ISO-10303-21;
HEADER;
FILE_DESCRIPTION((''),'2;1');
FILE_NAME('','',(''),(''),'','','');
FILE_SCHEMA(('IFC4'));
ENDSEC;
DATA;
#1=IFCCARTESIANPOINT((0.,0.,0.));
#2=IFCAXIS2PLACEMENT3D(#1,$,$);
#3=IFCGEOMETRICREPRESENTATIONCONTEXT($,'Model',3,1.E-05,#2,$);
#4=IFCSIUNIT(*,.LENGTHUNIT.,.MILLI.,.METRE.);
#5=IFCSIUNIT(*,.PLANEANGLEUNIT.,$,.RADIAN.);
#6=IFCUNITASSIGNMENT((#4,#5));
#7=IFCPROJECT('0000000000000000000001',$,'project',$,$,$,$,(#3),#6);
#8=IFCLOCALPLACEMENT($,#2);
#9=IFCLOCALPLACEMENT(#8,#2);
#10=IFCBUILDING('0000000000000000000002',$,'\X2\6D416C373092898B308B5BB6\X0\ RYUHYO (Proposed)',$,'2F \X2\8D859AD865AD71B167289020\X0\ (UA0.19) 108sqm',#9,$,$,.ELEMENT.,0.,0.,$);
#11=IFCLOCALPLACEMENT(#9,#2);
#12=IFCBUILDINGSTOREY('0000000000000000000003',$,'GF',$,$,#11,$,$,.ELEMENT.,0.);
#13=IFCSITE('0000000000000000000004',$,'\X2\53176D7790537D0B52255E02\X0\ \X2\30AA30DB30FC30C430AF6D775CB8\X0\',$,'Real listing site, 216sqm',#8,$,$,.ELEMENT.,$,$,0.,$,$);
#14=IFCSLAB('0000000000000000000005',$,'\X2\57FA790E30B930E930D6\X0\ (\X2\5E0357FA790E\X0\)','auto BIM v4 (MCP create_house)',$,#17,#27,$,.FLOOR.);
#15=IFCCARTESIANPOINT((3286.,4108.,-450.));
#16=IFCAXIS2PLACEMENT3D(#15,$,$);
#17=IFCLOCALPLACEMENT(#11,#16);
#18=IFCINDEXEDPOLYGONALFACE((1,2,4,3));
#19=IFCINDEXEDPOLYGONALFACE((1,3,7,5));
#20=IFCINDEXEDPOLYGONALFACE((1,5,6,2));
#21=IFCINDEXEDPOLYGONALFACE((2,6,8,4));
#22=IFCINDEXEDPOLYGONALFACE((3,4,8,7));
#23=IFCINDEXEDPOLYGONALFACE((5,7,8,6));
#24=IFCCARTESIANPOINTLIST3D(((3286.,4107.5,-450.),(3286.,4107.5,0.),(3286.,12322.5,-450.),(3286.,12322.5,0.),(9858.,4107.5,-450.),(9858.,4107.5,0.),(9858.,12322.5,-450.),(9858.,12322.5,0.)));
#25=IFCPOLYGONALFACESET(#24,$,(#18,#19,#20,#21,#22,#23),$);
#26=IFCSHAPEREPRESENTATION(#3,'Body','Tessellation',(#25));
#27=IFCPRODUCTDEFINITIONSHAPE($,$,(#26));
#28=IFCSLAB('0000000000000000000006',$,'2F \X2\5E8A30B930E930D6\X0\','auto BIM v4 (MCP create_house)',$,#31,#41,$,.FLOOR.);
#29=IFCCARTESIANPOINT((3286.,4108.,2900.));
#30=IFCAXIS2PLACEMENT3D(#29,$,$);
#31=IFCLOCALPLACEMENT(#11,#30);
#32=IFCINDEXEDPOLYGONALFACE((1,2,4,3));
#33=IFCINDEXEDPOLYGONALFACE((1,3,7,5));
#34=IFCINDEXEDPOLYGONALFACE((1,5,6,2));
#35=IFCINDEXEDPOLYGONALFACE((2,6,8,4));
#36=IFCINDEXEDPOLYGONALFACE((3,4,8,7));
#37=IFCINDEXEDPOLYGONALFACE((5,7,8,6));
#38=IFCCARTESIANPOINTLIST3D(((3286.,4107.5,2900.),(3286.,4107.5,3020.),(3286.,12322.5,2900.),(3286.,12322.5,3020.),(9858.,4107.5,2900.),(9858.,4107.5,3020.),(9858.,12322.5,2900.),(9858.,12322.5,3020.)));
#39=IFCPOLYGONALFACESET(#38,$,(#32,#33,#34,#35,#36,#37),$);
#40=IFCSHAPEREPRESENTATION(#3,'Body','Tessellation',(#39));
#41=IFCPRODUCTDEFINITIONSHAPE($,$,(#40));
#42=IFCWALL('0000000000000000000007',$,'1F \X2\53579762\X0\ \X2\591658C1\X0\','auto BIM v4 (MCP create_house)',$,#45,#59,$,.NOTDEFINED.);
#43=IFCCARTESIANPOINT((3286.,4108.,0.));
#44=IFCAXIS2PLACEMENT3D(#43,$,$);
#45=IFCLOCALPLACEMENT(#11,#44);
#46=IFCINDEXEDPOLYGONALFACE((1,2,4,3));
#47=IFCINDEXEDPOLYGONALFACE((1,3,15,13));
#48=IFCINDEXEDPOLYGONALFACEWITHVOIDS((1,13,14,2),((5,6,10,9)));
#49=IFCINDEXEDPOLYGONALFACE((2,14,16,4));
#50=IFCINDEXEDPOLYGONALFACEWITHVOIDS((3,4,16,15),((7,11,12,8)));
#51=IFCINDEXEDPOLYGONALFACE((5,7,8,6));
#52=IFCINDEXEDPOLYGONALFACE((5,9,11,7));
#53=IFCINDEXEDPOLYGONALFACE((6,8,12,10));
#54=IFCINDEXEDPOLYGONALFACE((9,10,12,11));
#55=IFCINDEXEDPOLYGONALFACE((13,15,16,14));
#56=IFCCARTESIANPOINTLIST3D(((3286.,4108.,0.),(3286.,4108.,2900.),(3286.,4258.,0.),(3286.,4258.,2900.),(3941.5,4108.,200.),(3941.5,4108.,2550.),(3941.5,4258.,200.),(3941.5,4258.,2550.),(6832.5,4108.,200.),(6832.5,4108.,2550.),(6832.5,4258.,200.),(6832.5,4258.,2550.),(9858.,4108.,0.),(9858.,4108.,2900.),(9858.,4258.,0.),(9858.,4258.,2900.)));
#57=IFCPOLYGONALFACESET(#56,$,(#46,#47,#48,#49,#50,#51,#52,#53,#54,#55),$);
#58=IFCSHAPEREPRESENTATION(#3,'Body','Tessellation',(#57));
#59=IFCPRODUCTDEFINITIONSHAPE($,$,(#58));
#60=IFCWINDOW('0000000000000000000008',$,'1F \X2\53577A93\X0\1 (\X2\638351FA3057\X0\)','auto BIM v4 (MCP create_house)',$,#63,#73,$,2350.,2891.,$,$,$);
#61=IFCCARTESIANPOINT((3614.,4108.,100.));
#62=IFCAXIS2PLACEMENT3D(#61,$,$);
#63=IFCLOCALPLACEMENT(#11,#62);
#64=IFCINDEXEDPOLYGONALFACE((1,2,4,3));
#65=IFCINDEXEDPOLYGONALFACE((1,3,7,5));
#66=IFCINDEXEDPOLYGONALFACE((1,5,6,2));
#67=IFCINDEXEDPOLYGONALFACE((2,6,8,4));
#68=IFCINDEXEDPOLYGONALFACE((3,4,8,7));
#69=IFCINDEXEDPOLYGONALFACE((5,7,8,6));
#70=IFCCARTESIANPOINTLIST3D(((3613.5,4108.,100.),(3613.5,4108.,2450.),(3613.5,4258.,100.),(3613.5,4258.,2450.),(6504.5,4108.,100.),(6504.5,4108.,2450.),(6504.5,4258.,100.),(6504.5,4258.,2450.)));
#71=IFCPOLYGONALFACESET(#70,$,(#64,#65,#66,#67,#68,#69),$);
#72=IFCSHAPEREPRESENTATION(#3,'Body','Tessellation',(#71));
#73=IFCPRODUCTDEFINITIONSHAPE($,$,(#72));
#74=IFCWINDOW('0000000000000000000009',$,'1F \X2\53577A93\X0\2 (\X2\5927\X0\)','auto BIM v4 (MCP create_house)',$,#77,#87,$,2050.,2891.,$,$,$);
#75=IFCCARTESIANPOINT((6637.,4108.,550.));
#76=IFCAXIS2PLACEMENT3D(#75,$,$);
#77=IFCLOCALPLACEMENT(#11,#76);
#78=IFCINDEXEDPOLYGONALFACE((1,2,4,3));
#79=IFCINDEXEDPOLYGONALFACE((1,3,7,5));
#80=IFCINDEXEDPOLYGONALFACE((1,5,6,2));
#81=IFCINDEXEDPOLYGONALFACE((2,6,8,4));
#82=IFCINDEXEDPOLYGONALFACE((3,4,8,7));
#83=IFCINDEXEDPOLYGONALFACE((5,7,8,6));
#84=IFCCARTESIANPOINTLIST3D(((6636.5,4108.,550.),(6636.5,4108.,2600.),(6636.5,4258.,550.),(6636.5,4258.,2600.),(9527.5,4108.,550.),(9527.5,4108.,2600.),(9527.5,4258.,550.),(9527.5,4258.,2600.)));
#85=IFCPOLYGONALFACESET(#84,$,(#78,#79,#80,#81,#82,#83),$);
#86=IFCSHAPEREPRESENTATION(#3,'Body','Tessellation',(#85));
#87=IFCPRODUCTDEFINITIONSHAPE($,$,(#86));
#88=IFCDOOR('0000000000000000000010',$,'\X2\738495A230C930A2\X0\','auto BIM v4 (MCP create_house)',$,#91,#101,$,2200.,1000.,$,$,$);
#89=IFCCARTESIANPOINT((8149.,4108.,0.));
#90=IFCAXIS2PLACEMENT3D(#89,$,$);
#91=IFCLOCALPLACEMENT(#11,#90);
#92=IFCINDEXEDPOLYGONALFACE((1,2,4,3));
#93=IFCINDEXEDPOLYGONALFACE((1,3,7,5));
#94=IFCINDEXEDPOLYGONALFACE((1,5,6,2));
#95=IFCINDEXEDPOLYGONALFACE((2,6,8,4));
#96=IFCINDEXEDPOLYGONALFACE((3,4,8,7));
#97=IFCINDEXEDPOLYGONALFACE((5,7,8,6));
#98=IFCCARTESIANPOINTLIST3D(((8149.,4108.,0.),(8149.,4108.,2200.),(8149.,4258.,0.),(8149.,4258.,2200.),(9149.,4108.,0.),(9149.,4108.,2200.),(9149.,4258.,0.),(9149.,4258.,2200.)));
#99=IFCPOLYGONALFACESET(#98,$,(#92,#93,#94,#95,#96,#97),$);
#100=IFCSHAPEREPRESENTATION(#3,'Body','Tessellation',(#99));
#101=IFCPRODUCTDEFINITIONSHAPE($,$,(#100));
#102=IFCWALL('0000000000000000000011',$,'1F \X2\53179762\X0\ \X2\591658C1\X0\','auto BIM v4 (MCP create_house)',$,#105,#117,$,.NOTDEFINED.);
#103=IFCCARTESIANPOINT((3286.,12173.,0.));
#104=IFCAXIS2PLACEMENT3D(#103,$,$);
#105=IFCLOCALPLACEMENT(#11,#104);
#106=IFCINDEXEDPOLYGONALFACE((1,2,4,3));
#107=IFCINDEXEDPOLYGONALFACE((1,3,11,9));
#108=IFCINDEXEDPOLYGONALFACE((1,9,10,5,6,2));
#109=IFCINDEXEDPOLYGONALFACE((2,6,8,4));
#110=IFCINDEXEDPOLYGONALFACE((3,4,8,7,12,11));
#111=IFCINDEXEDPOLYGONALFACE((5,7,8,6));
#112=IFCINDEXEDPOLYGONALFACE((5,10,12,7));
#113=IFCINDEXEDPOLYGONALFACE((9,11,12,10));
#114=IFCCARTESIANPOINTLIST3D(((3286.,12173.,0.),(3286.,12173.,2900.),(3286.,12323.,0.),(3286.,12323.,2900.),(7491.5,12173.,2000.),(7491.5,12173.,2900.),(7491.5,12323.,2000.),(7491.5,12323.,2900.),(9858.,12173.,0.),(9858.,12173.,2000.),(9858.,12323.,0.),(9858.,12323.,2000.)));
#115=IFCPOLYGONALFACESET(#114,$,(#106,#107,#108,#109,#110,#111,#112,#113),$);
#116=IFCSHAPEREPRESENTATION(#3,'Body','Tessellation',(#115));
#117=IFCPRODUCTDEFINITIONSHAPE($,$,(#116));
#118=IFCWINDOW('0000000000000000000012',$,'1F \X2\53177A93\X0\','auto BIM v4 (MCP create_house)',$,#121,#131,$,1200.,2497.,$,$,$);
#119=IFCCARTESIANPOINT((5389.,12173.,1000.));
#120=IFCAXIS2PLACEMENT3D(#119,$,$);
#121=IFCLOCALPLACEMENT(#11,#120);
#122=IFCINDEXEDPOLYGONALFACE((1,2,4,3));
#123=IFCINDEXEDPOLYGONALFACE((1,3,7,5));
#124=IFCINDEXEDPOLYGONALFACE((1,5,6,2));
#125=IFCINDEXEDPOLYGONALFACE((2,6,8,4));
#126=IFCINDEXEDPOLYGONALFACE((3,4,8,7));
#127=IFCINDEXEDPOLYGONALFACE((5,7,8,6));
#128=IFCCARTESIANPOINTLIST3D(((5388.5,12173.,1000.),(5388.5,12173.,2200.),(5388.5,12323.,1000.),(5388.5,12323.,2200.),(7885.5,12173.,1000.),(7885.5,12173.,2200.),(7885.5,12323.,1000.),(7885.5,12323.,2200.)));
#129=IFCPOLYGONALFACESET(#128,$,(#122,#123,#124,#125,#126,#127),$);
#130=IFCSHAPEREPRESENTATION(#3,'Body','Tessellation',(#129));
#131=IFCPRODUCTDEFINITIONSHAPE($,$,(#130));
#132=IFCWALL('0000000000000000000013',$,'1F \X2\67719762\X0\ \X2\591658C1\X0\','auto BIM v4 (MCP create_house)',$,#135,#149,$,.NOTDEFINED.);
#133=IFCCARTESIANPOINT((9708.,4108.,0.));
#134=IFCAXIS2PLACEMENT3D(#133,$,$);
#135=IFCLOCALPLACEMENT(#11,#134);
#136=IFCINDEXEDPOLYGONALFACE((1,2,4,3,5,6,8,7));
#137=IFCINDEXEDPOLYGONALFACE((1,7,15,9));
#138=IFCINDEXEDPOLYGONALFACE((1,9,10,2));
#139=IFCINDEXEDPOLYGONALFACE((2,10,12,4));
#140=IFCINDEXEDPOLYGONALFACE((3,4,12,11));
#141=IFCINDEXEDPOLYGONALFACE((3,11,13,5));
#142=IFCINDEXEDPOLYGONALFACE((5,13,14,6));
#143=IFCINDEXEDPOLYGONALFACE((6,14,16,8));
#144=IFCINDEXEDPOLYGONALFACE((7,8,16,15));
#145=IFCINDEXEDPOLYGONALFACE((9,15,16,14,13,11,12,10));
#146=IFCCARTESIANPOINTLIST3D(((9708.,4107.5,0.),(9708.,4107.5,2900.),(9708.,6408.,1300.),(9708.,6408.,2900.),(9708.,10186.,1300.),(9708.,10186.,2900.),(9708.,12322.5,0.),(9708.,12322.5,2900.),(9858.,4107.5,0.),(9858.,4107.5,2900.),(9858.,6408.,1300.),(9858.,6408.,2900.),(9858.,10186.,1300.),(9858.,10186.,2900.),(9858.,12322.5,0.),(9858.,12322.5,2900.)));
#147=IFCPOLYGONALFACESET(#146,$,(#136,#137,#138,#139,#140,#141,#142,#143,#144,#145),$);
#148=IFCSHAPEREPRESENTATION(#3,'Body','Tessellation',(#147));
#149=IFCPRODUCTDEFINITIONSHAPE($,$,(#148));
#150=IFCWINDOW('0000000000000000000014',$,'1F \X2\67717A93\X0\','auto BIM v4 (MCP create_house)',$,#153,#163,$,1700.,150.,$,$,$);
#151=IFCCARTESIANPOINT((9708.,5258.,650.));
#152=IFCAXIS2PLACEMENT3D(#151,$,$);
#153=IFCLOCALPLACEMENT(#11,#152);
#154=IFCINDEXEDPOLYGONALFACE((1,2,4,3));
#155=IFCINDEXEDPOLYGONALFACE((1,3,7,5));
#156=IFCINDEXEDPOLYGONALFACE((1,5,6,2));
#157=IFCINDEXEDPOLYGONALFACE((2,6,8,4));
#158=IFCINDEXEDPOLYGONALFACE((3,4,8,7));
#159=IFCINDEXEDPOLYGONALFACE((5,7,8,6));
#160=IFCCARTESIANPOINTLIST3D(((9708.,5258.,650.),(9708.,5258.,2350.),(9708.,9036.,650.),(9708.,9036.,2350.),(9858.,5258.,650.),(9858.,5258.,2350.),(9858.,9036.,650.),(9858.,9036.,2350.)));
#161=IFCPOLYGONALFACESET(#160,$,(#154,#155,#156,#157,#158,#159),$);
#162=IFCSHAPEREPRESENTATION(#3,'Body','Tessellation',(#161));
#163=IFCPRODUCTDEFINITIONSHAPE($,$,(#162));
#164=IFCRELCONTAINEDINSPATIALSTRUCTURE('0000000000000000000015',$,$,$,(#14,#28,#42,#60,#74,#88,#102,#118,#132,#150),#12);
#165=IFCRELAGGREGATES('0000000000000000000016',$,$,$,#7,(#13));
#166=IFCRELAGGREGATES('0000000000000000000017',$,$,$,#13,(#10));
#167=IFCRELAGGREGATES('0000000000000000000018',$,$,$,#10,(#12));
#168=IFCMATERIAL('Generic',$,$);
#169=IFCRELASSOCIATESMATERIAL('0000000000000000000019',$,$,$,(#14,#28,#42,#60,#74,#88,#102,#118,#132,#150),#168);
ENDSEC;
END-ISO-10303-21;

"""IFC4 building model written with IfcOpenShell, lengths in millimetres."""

from ifc_helpers import new_model, si_unit, frame, frame_2d, origin, place, context, project, spatial, rectangle, extrude, material, element, fill, save


model = new_model("IFC4")

# Units and contexts
model_context = context("Model", 3, precision=1e-05, world=origin())
ifc_project = project(units=[si_unit("LENGTHUNIT", "METRE", prefix="MILLI"), si_unit("PLANEANGLEUNIT", "RADIAN")], contexts=[model_context])

# Site, building, storey
site_placement = place(None, origin())
site = spatial("IfcSite", under=ifc_project, at=site_placement, Name="北海道紋別市 オホーツク海岸", ObjectType="Real listing site, 216sqm", CompositionType="ELEMENT", RefElevation=0.0)
building_placement = place(site_placement, origin())
building = spatial("IfcBuilding", under=site, at=building_placement, Name="流氷を見る家 RYUHYO (Proposed)", ObjectType="2F 超高断熱木造 (UA0.19) 108sqm", CompositionType="ELEMENT", ElevationOfRefHeight=0.0, ElevationOfTerrain=0.0)
storey_placement = place(building_placement, origin())
storey = spatial("IfcBuildingStorey", under=building, at=storey_placement, Name="GF", CompositionType="ELEMENT", Elevation=0.0)

# Slabs
ifc_material = material(Name="Generic")
slab_1_placement = place(storey_placement, frame((3286.0, 4108.0, -450.0)))
element("IfcSlab", 1, at=slab_1_placement, inside=storey, material=ifc_material, Name="基礎スラブ (布基礎)", Description="auto BIM v4 (MCP create_house)", PredefinedType="FLOOR", context=model_context, shape_type="SweptSolid", body=[
    extrude(rectangle(XDim=6572.0, YDim=8215.0, at=frame_2d((3286.0, 4107.0))), frame((3286.0, 4108.0, -450.0)), (0.0, 0.0, 1.0), 450.0),
])
slab_2_placement = place(storey_placement, frame((3286.0, 4108.0, 2900.0)))
element("IfcSlab", 2, at=slab_2_placement, inside=storey, material=ifc_material, Name="2F 床スラブ", Description="auto BIM v4 (MCP create_house)", PredefinedType="FLOOR", context=model_context, shape_type="SweptSolid", body=[
    extrude(rectangle(XDim=6572.0, YDim=8215.0, at=frame_2d((3286.0, 4107.0))), frame((3286.0, 4108.0, 2900.0)), (0.0, 0.0, 1.0), 120.0),
])

# Wall, openings, windows, door
wall_1_placement = place(storey_placement, frame((3286.0, 4108.0, 0.0)))
wall_1 = element("IfcWall", 3, at=wall_1_placement, inside=storey, material=ifc_material, Name="1F 南面 外壁", Description="auto BIM v4 (MCP create_house)", PredefinedType="NOTDEFINED", context=model_context, shape_type="SweptSolid", body=[
    extrude(rectangle(XDim=6572.0, YDim=150.0, at=frame_2d((3286.0, 75.0))), frame((3286.0, 4108.0, 0.0)), (0.0, 0.0, 1.0), 2900.0),
])
opening_1_placement = place(storey_placement, frame((3614.0, 4108.0, 100.0)))
opening_1 = element("IfcOpeningElement", 4, at=opening_1_placement, cuts=wall_1, PredefinedType="NOTDEFINED", context=model_context, shape_type="SweptSolid", body=[
    extrude(rectangle(XDim=2891.0, YDim=150.0, at=frame_2d((1445.0, 75.0))), frame((3614.0, 4108.0, 100.0)), (0.0, 0.0, 1.0), 2350.0),
])
opening_2_placement = place(storey_placement, frame((6637.0, 4108.0, 550.0)))
opening_2 = element("IfcOpeningElement", 5, at=opening_2_placement, cuts=wall_1, PredefinedType="NOTDEFINED", context=model_context, shape_type="SweptSolid", body=[
    extrude(rectangle(XDim=2891.0, YDim=150.0, at=frame_2d((1445.0, 75.0))), frame((6637.0, 4108.0, 550.0)), (0.0, 0.0, 1.0), 2050.0),
])
opening_3_placement = place(storey_placement, frame((8149.0, 4108.0, 0.0)))
opening_3 = element("IfcOpeningElement", 6, at=opening_3_placement, cuts=wall_1, PredefinedType="NOTDEFINED", context=model_context, shape_type="SweptSolid", body=[
    extrude(rectangle(XDim=1000.0, YDim=150.0, at=frame_2d((500.0, 75.0))), frame((8149.0, 4108.0, 0.0)), (0.0, 0.0, 1.0), 2200.0),
])
window_1_placement = place(storey_placement, frame((3614.0, 4108.0, 100.0)))
window_1 = element("IfcWindow", 7, at=window_1_placement, inside=storey, material=ifc_material, Name="1F 南窓1 (掃出し)", Description="auto BIM v4 (MCP create_house)", OverallHeight=2350.0, OverallWidth=2891.0, context=model_context, shape_type="SweptSolid", body=[
    extrude(rectangle(XDim=2891.0, YDim=150.0, at=frame_2d((1445.0, 75.0))), frame((3614.0, 4108.0, 100.0)), (0.0, 0.0, 1.0), 2350.0),
])
fill(opening_1, window_1)
window_2_placement = place(storey_placement, frame((6637.0, 4108.0, 550.0)))
window_2 = element("IfcWindow", 8, at=window_2_placement, inside=storey, material=ifc_material, Name="1F 南窓2 (大)", Description="auto BIM v4 (MCP create_house)", OverallHeight=2050.0, OverallWidth=2891.0, context=model_context, shape_type="SweptSolid", body=[
    extrude(rectangle(XDim=2891.0, YDim=150.0, at=frame_2d((1445.0, 75.0))), frame((6637.0, 4108.0, 550.0)), (0.0, 0.0, 1.0), 2050.0),
])
fill(opening_2, window_2)
door_1_placement = place(storey_placement, frame((8149.0, 4108.0, 0.0)))
door_1 = element("IfcDoor", 9, at=door_1_placement, inside=storey, material=ifc_material, Name="玄関ドア", Description="auto BIM v4 (MCP create_house)", OverallHeight=2200.0, OverallWidth=1000.0, context=model_context, shape_type="SweptSolid", body=[
    extrude(rectangle(XDim=1000.0, YDim=150.0, at=frame_2d((500.0, 75.0))), frame((8149.0, 4108.0, 0.0)), (0.0, 0.0, 1.0), 2200.0),
])
fill(opening_3, door_1)

# Walls, openings, windows
wall_2_placement = place(storey_placement, frame((3286.0, 12173.0, 0.0)))
wall_2 = element("IfcWall", 10, at=wall_2_placement, inside=storey, material=ifc_material, Name="1F 北面 外壁", Description="auto BIM v4 (MCP create_house)", PredefinedType="NOTDEFINED", context=model_context, shape_type="SweptSolid", body=[
    extrude(rectangle(XDim=6572.0, YDim=150.0, at=frame_2d((3286.0, 75.0))), frame((3286.0, 12173.0, 0.0)), (0.0, 0.0, 1.0), 2900.0),
])
opening_4_placement = place(storey_placement, frame((5389.0, 12173.0, 1000.0)))
opening_4 = element("IfcOpeningElement", 11, at=opening_4_placement, cuts=wall_2, PredefinedType="NOTDEFINED", context=model_context, shape_type="SweptSolid", body=[
    extrude(rectangle(XDim=2497.0, YDim=150.0, at=frame_2d((1248.0, 75.0))), frame((5389.0, 12173.0, 1000.0)), (0.0, 0.0, 1.0), 1200.0),
])
window_3_placement = place(storey_placement, frame((5389.0, 12173.0, 1000.0)))
window_3 = element("IfcWindow", 12, at=window_3_placement, inside=storey, material=ifc_material, Name="1F 北窓", Description="auto BIM v4 (MCP create_house)", OverallHeight=1200.0, OverallWidth=2497.0, context=model_context, shape_type="SweptSolid", body=[
    extrude(rectangle(XDim=2497.0, YDim=150.0, at=frame_2d((1248.0, 75.0))), frame((5389.0, 12173.0, 1000.0)), (0.0, 0.0, 1.0), 1200.0),
])
fill(opening_4, window_3)
wall_3_placement = place(storey_placement, frame((9708.0, 4108.0, 0.0)))
wall_3 = element("IfcWall", 13, at=wall_3_placement, inside=storey, material=ifc_material, Name="1F 東面 外壁", Description="auto BIM v4 (MCP create_house)", PredefinedType="NOTDEFINED", context=model_context, shape_type="SweptSolid", body=[
    extrude(rectangle(XDim=150.0, YDim=8215.0, at=frame_2d((75.0, 4107.0))), frame((9708.0, 4108.0, 0.0)), (0.0, 0.0, 1.0), 2900.0),
])
opening_5_placement = place(storey_placement, frame((9708.0, 5258.0, 650.0)))
opening_5 = element("IfcOpeningElement", 14, at=opening_5_placement, cuts=wall_3, PredefinedType="NOTDEFINED", context=model_context, shape_type="SweptSolid", body=[
    extrude(rectangle(XDim=150.0, YDim=3778.0, at=frame_2d((75.0, 1889.0))), frame((9708.0, 5258.0, 650.0)), (0.0, 0.0, 1.0), 1700.0),
])
window_4_placement = place(storey_placement, frame((9708.0, 5258.0, 650.0)))
window_4 = element("IfcWindow", 15, at=window_4_placement, inside=storey, material=ifc_material, Name="1F 東窓", Description="auto BIM v4 (MCP create_house)", OverallHeight=1700.0, OverallWidth=150.0, context=model_context, shape_type="SweptSolid", body=[
    extrude(rectangle(XDim=150.0, YDim=3778.0, at=frame_2d((75.0, 1889.0))), frame((9708.0, 5258.0, 650.0)), (0.0, 0.0, 1.0), 1700.0),
])
fill(opening_5, window_4)

save(model, "model.ifc")
